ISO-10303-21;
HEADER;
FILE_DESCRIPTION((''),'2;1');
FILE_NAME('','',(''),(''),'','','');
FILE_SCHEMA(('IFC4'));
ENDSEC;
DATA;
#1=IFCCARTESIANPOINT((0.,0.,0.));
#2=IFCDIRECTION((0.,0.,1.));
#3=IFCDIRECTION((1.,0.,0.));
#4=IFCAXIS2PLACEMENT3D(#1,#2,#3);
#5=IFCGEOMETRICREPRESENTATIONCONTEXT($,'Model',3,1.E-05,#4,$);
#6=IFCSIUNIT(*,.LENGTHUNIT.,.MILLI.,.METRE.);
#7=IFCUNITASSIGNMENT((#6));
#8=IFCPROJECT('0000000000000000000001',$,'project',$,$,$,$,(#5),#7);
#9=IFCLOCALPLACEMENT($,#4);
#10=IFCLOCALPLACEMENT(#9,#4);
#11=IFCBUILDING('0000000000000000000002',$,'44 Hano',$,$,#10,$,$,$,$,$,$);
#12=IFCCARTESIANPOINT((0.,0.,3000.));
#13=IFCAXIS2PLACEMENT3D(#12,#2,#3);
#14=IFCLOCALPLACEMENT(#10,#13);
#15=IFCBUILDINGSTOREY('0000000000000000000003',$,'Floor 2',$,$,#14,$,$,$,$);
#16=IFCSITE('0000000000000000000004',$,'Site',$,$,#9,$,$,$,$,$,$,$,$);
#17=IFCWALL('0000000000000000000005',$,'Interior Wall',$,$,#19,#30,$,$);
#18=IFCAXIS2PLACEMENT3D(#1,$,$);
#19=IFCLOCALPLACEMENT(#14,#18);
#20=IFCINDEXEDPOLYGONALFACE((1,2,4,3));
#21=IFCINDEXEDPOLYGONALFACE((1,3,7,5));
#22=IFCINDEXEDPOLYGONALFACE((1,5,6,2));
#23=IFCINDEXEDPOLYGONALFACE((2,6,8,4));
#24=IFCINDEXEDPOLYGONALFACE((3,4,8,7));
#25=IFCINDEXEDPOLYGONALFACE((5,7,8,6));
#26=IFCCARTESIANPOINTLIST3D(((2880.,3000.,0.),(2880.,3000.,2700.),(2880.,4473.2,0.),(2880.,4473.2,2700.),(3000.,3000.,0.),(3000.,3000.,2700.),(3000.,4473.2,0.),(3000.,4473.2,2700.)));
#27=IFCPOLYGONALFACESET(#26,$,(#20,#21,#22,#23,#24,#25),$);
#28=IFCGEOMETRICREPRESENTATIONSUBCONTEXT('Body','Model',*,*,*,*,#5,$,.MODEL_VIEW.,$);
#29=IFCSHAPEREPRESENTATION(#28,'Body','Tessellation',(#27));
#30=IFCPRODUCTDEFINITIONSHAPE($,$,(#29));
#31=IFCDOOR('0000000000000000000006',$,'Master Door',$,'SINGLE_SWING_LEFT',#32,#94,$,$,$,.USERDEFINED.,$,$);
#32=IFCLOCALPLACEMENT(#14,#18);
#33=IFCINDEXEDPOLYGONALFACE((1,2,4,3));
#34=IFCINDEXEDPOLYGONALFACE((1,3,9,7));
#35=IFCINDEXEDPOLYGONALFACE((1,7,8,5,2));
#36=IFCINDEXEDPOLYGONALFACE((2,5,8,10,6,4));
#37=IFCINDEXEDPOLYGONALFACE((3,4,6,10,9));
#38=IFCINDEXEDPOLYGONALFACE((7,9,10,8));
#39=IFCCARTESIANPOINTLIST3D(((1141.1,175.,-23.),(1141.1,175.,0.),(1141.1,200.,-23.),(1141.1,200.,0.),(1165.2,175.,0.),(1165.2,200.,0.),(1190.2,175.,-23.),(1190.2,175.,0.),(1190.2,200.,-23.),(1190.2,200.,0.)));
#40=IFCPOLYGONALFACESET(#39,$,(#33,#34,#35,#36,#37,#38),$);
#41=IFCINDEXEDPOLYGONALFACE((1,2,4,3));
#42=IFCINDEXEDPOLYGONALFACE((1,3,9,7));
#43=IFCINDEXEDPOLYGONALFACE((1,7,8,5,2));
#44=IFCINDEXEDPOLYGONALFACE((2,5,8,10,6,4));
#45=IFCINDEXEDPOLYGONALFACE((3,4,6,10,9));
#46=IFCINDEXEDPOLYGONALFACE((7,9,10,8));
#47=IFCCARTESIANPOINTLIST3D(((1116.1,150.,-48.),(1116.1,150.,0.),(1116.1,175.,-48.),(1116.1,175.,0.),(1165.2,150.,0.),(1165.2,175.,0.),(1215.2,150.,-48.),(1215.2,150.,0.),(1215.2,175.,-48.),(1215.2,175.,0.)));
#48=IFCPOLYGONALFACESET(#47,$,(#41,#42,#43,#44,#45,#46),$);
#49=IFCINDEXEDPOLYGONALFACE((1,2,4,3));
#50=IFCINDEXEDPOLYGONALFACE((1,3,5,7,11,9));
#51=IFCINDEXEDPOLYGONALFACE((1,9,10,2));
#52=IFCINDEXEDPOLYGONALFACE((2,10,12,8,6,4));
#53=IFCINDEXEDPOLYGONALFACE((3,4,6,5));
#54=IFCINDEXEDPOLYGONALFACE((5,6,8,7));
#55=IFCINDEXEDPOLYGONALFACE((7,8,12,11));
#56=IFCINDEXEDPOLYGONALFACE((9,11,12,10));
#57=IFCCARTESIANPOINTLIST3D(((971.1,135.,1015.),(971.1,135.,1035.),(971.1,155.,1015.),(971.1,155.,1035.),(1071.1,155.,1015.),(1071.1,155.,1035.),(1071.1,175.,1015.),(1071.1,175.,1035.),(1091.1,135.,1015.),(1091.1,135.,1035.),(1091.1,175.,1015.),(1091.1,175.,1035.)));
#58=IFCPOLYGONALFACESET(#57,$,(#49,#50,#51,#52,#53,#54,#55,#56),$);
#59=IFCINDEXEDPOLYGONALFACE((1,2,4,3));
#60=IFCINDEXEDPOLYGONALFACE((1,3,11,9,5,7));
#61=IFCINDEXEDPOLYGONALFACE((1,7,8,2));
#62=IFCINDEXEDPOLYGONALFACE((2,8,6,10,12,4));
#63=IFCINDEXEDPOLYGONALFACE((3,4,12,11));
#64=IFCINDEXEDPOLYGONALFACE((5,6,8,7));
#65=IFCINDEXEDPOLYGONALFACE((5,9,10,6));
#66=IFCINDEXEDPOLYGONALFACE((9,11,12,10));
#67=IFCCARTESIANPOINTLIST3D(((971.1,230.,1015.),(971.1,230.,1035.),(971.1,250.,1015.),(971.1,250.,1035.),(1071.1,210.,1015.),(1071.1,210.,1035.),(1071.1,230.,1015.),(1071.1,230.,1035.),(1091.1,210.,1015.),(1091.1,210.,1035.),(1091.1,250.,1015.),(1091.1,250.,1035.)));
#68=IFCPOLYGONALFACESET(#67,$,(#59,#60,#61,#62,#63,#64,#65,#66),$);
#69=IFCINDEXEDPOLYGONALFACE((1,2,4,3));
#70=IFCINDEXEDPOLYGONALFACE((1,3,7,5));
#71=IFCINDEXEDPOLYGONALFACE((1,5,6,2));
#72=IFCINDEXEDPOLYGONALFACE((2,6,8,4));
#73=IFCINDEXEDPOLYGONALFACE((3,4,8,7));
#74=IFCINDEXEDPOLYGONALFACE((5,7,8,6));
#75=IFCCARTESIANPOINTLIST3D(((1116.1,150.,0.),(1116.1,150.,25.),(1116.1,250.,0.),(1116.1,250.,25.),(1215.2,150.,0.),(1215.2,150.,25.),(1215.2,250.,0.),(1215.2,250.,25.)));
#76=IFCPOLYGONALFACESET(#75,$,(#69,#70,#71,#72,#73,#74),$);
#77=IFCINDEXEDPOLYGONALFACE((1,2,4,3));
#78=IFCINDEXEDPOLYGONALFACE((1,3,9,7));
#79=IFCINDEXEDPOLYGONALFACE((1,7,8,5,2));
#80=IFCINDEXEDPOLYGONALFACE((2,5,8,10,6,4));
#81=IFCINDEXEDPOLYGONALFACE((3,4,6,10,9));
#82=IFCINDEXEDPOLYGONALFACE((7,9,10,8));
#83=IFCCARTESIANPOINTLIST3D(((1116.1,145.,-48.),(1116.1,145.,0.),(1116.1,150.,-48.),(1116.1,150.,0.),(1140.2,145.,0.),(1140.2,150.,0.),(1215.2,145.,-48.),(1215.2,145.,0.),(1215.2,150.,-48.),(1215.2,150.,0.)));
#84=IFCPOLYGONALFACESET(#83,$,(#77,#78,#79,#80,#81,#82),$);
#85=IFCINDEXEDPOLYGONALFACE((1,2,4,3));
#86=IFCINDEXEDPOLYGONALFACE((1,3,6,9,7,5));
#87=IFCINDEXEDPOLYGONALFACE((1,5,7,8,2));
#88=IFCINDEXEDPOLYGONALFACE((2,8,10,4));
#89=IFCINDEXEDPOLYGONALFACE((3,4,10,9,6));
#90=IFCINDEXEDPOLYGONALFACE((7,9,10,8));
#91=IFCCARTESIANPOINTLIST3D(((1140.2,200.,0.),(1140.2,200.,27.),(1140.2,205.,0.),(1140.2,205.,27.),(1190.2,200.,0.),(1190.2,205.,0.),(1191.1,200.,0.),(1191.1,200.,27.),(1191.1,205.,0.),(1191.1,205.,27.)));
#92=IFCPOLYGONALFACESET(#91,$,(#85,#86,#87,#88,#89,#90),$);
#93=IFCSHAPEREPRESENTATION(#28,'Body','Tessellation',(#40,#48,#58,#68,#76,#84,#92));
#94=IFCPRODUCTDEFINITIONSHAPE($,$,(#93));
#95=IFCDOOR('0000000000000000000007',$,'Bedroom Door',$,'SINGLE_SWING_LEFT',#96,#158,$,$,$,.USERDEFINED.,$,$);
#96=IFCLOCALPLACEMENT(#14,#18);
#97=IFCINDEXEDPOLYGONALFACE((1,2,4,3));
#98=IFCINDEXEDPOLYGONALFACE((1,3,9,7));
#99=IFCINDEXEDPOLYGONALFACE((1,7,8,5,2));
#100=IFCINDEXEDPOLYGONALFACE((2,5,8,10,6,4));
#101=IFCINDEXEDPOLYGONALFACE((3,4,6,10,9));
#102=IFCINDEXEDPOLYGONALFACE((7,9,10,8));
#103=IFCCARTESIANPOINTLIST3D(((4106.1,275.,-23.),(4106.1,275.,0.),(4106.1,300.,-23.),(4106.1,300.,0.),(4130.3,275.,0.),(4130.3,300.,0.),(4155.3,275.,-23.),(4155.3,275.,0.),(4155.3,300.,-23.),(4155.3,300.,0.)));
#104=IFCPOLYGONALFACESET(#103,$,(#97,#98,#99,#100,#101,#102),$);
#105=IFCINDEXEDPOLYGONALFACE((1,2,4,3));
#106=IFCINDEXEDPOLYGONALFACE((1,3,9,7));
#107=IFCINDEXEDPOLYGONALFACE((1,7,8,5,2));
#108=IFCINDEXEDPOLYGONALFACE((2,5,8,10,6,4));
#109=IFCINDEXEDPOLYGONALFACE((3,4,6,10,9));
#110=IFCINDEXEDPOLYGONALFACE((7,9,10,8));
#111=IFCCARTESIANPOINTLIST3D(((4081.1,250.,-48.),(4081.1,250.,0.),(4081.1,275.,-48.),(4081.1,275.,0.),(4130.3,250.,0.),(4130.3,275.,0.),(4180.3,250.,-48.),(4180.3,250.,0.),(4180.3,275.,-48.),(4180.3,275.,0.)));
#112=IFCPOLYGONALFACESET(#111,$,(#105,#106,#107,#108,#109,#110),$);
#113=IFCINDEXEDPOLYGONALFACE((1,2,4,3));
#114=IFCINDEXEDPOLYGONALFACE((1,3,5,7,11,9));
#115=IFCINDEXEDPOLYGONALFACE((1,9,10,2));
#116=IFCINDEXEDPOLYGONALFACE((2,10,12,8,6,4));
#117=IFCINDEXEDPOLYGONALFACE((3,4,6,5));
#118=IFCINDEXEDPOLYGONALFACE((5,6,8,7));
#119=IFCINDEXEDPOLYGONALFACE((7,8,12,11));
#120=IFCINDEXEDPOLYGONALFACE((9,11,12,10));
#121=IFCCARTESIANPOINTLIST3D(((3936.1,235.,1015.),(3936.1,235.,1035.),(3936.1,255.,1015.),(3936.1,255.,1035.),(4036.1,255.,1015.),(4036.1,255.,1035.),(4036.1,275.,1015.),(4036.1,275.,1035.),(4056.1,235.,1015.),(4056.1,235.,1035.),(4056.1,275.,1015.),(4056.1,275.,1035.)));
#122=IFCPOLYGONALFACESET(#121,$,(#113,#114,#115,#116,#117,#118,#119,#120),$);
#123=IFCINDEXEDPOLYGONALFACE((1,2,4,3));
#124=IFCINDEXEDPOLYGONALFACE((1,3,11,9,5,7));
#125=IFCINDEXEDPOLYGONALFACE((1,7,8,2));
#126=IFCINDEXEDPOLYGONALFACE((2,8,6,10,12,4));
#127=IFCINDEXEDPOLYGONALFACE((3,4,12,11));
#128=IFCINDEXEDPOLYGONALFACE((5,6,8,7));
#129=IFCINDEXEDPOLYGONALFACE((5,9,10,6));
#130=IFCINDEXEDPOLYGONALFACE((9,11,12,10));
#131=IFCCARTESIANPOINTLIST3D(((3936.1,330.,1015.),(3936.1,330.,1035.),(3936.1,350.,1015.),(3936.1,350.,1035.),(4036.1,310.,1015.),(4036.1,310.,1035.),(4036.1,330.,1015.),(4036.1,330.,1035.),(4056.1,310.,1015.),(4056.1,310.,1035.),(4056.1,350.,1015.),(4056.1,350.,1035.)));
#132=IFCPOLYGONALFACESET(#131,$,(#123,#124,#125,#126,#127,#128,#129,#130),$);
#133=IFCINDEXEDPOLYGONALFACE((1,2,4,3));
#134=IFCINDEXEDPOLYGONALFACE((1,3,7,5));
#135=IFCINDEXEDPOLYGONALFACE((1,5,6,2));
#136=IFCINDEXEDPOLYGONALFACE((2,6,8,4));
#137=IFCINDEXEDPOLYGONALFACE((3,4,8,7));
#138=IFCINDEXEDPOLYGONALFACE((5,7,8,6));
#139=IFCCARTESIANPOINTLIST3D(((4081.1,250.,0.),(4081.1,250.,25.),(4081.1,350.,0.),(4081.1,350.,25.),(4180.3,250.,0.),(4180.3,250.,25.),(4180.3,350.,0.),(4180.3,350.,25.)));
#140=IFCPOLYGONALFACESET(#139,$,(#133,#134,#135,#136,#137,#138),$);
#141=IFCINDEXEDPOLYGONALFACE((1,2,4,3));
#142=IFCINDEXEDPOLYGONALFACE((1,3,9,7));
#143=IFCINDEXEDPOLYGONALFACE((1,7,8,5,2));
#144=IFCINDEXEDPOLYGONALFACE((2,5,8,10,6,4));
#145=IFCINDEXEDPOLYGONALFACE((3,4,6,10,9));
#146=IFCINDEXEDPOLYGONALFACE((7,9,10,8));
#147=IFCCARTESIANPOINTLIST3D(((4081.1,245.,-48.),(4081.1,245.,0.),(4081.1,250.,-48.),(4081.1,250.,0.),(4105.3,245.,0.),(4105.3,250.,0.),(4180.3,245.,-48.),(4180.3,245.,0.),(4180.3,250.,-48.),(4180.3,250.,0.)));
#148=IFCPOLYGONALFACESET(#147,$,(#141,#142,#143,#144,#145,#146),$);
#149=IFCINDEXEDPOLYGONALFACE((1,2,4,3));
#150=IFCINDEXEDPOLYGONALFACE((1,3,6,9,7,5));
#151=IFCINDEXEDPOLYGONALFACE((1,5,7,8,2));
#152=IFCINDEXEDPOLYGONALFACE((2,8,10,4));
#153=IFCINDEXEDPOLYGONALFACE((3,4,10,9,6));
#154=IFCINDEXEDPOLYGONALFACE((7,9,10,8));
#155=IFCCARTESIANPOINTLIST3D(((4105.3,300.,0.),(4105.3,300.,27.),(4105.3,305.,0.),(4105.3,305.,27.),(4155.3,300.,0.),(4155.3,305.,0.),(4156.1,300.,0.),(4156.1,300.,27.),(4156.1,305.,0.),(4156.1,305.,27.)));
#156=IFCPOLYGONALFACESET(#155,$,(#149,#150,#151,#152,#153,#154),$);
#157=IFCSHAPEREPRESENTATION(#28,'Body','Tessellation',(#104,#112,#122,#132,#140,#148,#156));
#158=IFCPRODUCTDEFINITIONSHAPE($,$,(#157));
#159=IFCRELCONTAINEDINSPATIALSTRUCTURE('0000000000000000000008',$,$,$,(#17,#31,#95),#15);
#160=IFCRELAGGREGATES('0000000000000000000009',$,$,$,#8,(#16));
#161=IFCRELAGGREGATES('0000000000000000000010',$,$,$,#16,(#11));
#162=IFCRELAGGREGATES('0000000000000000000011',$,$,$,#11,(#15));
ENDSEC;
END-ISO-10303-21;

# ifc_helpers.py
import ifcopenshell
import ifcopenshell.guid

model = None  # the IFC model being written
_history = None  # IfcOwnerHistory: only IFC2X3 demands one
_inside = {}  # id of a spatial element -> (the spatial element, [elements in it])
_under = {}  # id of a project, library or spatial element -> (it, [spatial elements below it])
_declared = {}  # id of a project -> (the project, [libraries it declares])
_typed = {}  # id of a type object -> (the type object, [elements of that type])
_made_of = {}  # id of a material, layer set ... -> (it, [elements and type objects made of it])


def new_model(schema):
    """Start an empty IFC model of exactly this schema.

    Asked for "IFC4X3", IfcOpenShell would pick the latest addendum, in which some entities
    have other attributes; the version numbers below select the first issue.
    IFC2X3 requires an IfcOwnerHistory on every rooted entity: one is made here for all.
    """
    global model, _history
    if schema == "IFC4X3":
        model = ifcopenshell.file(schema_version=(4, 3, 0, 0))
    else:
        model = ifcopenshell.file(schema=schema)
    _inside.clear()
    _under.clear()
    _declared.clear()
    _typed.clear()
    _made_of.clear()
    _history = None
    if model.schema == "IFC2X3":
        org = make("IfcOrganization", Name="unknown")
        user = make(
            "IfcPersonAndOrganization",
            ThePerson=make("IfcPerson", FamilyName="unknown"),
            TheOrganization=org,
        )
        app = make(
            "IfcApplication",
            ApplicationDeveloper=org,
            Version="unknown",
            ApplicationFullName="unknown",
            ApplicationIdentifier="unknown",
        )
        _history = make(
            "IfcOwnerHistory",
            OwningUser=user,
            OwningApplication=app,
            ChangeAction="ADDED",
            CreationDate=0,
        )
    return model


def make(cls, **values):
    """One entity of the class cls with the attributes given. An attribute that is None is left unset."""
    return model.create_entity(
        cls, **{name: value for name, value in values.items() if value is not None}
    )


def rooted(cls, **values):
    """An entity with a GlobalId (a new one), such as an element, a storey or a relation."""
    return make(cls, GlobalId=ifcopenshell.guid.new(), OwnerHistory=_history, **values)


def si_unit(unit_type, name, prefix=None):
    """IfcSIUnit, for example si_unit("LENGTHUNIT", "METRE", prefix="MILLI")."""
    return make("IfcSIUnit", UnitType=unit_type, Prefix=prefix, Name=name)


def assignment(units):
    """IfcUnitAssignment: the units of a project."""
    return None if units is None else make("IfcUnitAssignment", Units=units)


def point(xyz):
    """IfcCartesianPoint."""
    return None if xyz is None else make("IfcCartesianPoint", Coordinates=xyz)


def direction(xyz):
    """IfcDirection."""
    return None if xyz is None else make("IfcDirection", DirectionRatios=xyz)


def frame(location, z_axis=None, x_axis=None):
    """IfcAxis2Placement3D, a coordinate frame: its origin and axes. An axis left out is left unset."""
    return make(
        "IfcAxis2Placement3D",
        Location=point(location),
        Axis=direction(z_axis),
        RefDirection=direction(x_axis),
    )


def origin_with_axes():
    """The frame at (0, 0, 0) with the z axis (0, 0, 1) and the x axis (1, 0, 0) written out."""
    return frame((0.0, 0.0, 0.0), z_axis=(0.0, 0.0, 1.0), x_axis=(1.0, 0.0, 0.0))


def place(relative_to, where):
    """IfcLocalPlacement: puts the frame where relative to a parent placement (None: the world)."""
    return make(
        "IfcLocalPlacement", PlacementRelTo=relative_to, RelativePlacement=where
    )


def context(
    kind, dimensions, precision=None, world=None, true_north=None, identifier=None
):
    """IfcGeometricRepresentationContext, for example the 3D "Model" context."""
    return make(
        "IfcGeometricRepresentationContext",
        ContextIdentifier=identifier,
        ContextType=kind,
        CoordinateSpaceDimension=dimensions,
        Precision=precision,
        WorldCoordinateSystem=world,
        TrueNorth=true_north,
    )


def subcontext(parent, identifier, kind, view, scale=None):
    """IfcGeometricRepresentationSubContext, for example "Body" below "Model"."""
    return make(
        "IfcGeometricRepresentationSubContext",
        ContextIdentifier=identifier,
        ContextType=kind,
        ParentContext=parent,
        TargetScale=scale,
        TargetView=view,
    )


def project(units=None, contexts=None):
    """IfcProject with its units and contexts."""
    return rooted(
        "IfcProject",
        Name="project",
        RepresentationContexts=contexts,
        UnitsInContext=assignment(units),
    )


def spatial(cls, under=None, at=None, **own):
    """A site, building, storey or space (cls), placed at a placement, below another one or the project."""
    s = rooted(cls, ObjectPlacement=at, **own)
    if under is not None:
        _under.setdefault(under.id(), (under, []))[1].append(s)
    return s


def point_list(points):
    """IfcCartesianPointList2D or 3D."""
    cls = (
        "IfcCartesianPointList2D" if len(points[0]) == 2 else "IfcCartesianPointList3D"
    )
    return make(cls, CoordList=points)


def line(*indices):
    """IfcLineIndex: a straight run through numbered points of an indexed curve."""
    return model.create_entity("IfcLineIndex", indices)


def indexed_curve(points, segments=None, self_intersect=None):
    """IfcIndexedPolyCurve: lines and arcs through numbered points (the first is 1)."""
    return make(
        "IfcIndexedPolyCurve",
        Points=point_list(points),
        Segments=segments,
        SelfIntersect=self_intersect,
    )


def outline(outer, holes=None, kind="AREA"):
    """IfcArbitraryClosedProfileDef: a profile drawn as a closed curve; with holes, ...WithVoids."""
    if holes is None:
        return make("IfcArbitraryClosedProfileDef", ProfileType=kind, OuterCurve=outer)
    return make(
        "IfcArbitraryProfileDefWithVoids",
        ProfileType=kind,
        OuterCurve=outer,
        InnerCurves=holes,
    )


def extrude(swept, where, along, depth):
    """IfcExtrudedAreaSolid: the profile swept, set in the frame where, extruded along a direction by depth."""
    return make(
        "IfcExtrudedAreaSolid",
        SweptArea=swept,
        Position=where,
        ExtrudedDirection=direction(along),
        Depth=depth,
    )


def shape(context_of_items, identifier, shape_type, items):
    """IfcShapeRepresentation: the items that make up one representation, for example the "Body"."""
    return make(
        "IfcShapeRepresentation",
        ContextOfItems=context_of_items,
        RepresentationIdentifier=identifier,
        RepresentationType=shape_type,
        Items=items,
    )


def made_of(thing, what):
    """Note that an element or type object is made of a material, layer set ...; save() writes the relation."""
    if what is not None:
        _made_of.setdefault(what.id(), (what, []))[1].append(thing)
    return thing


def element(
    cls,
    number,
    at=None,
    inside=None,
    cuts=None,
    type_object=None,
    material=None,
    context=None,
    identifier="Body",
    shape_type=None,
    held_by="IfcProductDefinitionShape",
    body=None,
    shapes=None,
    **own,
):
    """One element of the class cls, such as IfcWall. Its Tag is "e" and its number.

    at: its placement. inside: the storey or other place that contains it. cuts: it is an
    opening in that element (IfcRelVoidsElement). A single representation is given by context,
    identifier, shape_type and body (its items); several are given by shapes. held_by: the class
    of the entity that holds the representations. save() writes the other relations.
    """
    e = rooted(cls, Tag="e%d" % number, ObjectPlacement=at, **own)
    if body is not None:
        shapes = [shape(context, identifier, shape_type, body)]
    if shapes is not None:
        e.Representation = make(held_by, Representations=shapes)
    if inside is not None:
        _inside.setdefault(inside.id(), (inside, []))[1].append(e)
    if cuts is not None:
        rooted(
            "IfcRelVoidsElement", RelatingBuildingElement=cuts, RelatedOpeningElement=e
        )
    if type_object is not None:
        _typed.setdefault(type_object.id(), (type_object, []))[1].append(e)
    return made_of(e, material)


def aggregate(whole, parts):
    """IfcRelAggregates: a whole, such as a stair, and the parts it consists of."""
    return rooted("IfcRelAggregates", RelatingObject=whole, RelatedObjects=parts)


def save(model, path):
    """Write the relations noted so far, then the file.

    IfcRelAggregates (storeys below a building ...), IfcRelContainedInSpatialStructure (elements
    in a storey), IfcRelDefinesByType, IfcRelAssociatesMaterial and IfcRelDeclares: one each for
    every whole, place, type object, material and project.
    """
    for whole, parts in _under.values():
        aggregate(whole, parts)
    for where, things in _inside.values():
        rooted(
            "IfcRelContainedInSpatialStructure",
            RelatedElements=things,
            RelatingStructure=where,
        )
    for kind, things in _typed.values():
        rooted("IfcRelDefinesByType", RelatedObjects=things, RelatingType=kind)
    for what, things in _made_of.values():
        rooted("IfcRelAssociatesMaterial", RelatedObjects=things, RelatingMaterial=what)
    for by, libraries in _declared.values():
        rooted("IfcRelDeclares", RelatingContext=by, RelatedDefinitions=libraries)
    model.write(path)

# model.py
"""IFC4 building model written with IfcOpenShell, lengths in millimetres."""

from ifc_helpers import new_model, si_unit, frame, origin_with_axes, place, context, subcontext, project, spatial, line, indexed_curve, outline, extrude, element, save


model = new_model("IFC4")

# Units and contexts
model_context = context("Model", 3, precision=1e-05, world=origin_with_axes())
body_context = subcontext(model_context, "Body", "Model", "MODEL_VIEW")
ifc_project = project(units=[si_unit("LENGTHUNIT", "METRE", prefix="MILLI")], contexts=[model_context])

# Site, building, storey
site_placement = place(None, origin_with_axes())
site = spatial("IfcSite", under=ifc_project, at=site_placement, Name="Site")
building_placement = place(site_placement, origin_with_axes())
building = spatial("IfcBuilding", under=site, at=building_placement, Name="44 Hano")
storey_placement = place(building_placement, frame((0.0, 0.0, 3000.0), z_axis=(0.0, 0.0, 1.0), x_axis=(1.0, 0.0, 0.0)))
storey = spatial("IfcBuildingStorey", under=building, at=storey_placement, Name="Floor 2")

# Wall
wall_1_placement = place(storey_placement, frame((3000.0, 3000.0, 0.0), z_axis=(0.0, 0.0, 1.0), x_axis=(0.0, 1.0, 0.0)))
element("IfcWall", 1, at=wall_1_placement, inside=storey, Name="Interior Wall", context=body_context, shape_type="SweptSolid", body=[
    extrude(outline(indexed_curve([(0.0, 0.0), (0.0, 120.0), (1473.2, 120.0), (1473.2, 0.0), (0.0, 0.0)], self_intersect=False)), origin_with_axes(), (0.0, 0.0, 1.0), 2700.0),
])

# Doors
door_1_placement = place(storey_placement, frame((1165.2, 150.0, 0.0), z_axis=(0.0, 0.0, 1.0), x_axis=(1.0, 0.0, 0.0)))
element("IfcDoor", 2, at=door_1_placement, inside=storey, Name="Master Door", ObjectType="SINGLE_SWING_LEFT", PredefinedType="USERDEFINED", context=body_context, shape_type="SweptSolid", body=[
    extrude(outline(indexed_curve([(0.0, 0.0), (0.0, 2.0), (0.9, 2.0), (0.9, 0.0), (-24.1, 0.0), (-24.1, -23.0), (25.0, -23.0), (25.0, 0.0)], segments=[line(1, 2, 3, 4, 5, 6, 7, 8, 1)])), frame((0.0, 25.0, 0.0), z_axis=(0.0, -1.0, 0.0), x_axis=(1.0, 0.0, 0.0)), (0.0, 0.0, -1.0), 25.0),
    extrude(outline(indexed_curve([(0.0, 0.0), (0.0, 2.0), (0.9, 2.0), (0.9, 0.0), (-49.1, 0.0), (-49.1, -48.0), (50.0, -48.0), (50.0, 0.0)], segments=[line(1, 2, 3, 4, 5, 6, 7, 8, 1)])), frame((0.0, 0.0, 0.0), z_axis=(0.0, -1.0, 0.0), x_axis=(1.0, 0.0, 0.0)), (0.0, 0.0, -1.0), 25.0),
    extrude(outline(indexed_curve([(0.0, 0.0), (-49.1, 0.0), (-49.1, 35.0), (0.0, 35.0)], segments=[line(1, 2, 3, 4, 1)])), frame((25.0, 25.0, 25.0), z_axis=(0.0, 0.0, 1.0), x_axis=(1.0, 0.0, 0.0)), (0.0, 0.0, 1.0), -48.0),
    extrude(outline(indexed_curve([(0.0, 0.0), (0.0, -40.0), (-120.0, -40.0), (-120.0, -20.0), (-20.0, -20.0), (-20.0, 0.0)], segments=[line(1, 2, 3, 4, 5, 6, 1)])), frame((-74.1, 25.0, 1015.0), z_axis=(0.0, 0.0, 1.0), x_axis=(1.0, 0.0, 0.0)), (0.0, 0.0, 1.0), 20.0),
    extrude(outline(indexed_curve([(0.0, 0.0), (0.0, 40.0), (-120.0, 40.0), (-120.0, 20.0), (-20.0, 20.0), (-20.0, 0.0)], segments=[line(1, 2, 3, 4, 5, 6, 1)])), frame((-74.1, 60.0, 1015.0), z_axis=(0.0, 0.0, 1.0), x_axis=(1.0, 0.0, 0.0)), (0.0, 0.0, 1.0), 20.0),
    extrude(outline(indexed_curve([(0.0, 0.0), (-99.1, 0.0), (-99.1, 100.0), (0.0, 100.0)], segments=[line(1, 2, 3, 4, 1)])), frame((50.0, 0.0, 0.0), z_axis=(0.0, 0.0, 1.0), x_axis=(1.0, 0.0, 0.0)), (0.0, 0.0, 1.0), 25.0),
    extrude(outline(indexed_curve([(0.0, 0.0), (0.0, 27.0), (50.9, 27.0), (50.9, 0.0), (-24.1, 0.0), (-24.1, -48.0), (75.0, -48.0), (75.0, 0.0)], segments=[line(1, 2, 3, 4, 5, 6, 7, 8, 1)])), frame((-25.0, -5.0, 0.0), z_axis=(0.0, -1.0, 0.0), x_axis=(1.0, 0.0, 0.0)), (0.0, 0.0, -1.0), 5.0),
    extrude(outline(indexed_curve([(0.0, 0.0), (0.0, 27.0), (50.9, 27.0), (50.9, 0.0), (0.9, 0.0), (0.9, -23.0), (50.0, -23.0), (50.0, 0.0)], segments=[line(1, 2, 3, 4, 5, 6, 7, 8, 1)])), frame((-25.0, 50.0, 0.0), z_axis=(0.0, -1.0, 0.0), x_axis=(1.0, 0.0, 0.0)), (0.0, 0.0, -1.0), 5.0),
])
door_2_placement = place(storey_placement, frame((4130.3, 250.0, 0.0), z_axis=(0.0, 0.0, 1.0), x_axis=(1.0, 0.0, 0.0)))
element("IfcDoor", 3, at=door_2_placement, inside=storey, Name="Bedroom Door", ObjectType="SINGLE_SWING_LEFT", PredefinedType="USERDEFINED", context=body_context, shape_type="SweptSolid", body=[
    extrude(outline(indexed_curve([(0.0, 0.0), (0.0, 2.0), (0.8, 2.0), (0.8, 0.0), (-24.2, 0.0), (-24.2, -23.0), (25.0, -23.0), (25.0, 0.0)], segments=[line(1, 2, 3, 4, 5, 6, 7, 8, 1)])), frame((0.0, 25.0, 0.0), z_axis=(0.0, -1.0, 0.0), x_axis=(1.0, 0.0, 0.0)), (0.0, 0.0, -1.0), 25.0),
    extrude(outline(indexed_curve([(0.0, 0.0), (0.0, 2.0), (0.8, 2.0), (0.8, 0.0), (-49.2, 0.0), (-49.2, -48.0), (50.0, -48.0), (50.0, 0.0)], segments=[line(1, 2, 3, 4, 5, 6, 7, 8, 1)])), frame((0.0, 0.0, 0.0), z_axis=(0.0, -1.0, 0.0), x_axis=(1.0, 0.0, 0.0)), (0.0, 0.0, -1.0), 25.0),
    extrude(outline(indexed_curve([(0.0, 0.0), (-49.2, 0.0), (-49.2, 35.0), (0.0, 35.0)], segments=[line(1, 2, 3, 4, 1)])), frame((25.0, 25.0, 25.0), z_axis=(0.0, 0.0, 1.0), x_axis=(1.0, 0.0, 0.0)), (0.0, 0.0, 1.0), -48.0),
    extrude(outline(indexed_curve([(0.0, 0.0), (0.0, -40.0), (-120.0, -40.0), (-120.0, -20.0), (-20.0, -20.0), (-20.0, 0.0)], segments=[line(1, 2, 3, 4, 5, 6, 1)])), frame((-74.2, 25.0, 1015.0), z_axis=(0.0, 0.0, 1.0), x_axis=(1.0, 0.0, 0.0)), (0.0, 0.0, 1.0), 20.0),
    extrude(outline(indexed_curve([(0.0, 0.0), (0.0, 40.0), (-120.0, 40.0), (-120.0, 20.0), (-20.0, 20.0), (-20.0, 0.0)], segments=[line(1, 2, 3, 4, 5, 6, 1)])), frame((-74.2, 60.0, 1015.0), z_axis=(0.0, 0.0, 1.0), x_axis=(1.0, 0.0, 0.0)), (0.0, 0.0, 1.0), 20.0),
    extrude(outline(indexed_curve([(0.0, 0.0), (-99.2, 0.0), (-99.2, 100.0), (0.0, 100.0)], segments=[line(1, 2, 3, 4, 1)])), frame((50.0, 0.0, 0.0), z_axis=(0.0, 0.0, 1.0), x_axis=(1.0, 0.0, 0.0)), (0.0, 0.0, 1.0), 25.0),
    extrude(outline(indexed_curve([(0.0, 0.0), (0.0, 27.0), (50.8, 27.0), (50.8, 0.0), (-24.2, 0.0), (-24.2, -48.0), (75.0, -48.0), (75.0, 0.0)], segments=[line(1, 2, 3, 4, 5, 6, 7, 8, 1)])), frame((-25.0, -5.0, 0.0), z_axis=(0.0, -1.0, 0.0), x_axis=(1.0, 0.0, 0.0)), (0.0, 0.0, -1.0), 5.0),
    extrude(outline(indexed_curve([(0.0, 0.0), (0.0, 27.0), (50.8, 27.0), (50.8, 0.0), (0.8, 0.0), (0.8, -23.0), (50.0, -23.0), (50.0, 0.0)], segments=[line(1, 2, 3, 4, 5, 6, 7, 8, 1)])), frame((-25.0, 50.0, 0.0), z_axis=(0.0, -1.0, 0.0), x_axis=(1.0, 0.0, 0.0)), (0.0, 0.0, -1.0), 5.0),
])

save(model, "model.ifc")
